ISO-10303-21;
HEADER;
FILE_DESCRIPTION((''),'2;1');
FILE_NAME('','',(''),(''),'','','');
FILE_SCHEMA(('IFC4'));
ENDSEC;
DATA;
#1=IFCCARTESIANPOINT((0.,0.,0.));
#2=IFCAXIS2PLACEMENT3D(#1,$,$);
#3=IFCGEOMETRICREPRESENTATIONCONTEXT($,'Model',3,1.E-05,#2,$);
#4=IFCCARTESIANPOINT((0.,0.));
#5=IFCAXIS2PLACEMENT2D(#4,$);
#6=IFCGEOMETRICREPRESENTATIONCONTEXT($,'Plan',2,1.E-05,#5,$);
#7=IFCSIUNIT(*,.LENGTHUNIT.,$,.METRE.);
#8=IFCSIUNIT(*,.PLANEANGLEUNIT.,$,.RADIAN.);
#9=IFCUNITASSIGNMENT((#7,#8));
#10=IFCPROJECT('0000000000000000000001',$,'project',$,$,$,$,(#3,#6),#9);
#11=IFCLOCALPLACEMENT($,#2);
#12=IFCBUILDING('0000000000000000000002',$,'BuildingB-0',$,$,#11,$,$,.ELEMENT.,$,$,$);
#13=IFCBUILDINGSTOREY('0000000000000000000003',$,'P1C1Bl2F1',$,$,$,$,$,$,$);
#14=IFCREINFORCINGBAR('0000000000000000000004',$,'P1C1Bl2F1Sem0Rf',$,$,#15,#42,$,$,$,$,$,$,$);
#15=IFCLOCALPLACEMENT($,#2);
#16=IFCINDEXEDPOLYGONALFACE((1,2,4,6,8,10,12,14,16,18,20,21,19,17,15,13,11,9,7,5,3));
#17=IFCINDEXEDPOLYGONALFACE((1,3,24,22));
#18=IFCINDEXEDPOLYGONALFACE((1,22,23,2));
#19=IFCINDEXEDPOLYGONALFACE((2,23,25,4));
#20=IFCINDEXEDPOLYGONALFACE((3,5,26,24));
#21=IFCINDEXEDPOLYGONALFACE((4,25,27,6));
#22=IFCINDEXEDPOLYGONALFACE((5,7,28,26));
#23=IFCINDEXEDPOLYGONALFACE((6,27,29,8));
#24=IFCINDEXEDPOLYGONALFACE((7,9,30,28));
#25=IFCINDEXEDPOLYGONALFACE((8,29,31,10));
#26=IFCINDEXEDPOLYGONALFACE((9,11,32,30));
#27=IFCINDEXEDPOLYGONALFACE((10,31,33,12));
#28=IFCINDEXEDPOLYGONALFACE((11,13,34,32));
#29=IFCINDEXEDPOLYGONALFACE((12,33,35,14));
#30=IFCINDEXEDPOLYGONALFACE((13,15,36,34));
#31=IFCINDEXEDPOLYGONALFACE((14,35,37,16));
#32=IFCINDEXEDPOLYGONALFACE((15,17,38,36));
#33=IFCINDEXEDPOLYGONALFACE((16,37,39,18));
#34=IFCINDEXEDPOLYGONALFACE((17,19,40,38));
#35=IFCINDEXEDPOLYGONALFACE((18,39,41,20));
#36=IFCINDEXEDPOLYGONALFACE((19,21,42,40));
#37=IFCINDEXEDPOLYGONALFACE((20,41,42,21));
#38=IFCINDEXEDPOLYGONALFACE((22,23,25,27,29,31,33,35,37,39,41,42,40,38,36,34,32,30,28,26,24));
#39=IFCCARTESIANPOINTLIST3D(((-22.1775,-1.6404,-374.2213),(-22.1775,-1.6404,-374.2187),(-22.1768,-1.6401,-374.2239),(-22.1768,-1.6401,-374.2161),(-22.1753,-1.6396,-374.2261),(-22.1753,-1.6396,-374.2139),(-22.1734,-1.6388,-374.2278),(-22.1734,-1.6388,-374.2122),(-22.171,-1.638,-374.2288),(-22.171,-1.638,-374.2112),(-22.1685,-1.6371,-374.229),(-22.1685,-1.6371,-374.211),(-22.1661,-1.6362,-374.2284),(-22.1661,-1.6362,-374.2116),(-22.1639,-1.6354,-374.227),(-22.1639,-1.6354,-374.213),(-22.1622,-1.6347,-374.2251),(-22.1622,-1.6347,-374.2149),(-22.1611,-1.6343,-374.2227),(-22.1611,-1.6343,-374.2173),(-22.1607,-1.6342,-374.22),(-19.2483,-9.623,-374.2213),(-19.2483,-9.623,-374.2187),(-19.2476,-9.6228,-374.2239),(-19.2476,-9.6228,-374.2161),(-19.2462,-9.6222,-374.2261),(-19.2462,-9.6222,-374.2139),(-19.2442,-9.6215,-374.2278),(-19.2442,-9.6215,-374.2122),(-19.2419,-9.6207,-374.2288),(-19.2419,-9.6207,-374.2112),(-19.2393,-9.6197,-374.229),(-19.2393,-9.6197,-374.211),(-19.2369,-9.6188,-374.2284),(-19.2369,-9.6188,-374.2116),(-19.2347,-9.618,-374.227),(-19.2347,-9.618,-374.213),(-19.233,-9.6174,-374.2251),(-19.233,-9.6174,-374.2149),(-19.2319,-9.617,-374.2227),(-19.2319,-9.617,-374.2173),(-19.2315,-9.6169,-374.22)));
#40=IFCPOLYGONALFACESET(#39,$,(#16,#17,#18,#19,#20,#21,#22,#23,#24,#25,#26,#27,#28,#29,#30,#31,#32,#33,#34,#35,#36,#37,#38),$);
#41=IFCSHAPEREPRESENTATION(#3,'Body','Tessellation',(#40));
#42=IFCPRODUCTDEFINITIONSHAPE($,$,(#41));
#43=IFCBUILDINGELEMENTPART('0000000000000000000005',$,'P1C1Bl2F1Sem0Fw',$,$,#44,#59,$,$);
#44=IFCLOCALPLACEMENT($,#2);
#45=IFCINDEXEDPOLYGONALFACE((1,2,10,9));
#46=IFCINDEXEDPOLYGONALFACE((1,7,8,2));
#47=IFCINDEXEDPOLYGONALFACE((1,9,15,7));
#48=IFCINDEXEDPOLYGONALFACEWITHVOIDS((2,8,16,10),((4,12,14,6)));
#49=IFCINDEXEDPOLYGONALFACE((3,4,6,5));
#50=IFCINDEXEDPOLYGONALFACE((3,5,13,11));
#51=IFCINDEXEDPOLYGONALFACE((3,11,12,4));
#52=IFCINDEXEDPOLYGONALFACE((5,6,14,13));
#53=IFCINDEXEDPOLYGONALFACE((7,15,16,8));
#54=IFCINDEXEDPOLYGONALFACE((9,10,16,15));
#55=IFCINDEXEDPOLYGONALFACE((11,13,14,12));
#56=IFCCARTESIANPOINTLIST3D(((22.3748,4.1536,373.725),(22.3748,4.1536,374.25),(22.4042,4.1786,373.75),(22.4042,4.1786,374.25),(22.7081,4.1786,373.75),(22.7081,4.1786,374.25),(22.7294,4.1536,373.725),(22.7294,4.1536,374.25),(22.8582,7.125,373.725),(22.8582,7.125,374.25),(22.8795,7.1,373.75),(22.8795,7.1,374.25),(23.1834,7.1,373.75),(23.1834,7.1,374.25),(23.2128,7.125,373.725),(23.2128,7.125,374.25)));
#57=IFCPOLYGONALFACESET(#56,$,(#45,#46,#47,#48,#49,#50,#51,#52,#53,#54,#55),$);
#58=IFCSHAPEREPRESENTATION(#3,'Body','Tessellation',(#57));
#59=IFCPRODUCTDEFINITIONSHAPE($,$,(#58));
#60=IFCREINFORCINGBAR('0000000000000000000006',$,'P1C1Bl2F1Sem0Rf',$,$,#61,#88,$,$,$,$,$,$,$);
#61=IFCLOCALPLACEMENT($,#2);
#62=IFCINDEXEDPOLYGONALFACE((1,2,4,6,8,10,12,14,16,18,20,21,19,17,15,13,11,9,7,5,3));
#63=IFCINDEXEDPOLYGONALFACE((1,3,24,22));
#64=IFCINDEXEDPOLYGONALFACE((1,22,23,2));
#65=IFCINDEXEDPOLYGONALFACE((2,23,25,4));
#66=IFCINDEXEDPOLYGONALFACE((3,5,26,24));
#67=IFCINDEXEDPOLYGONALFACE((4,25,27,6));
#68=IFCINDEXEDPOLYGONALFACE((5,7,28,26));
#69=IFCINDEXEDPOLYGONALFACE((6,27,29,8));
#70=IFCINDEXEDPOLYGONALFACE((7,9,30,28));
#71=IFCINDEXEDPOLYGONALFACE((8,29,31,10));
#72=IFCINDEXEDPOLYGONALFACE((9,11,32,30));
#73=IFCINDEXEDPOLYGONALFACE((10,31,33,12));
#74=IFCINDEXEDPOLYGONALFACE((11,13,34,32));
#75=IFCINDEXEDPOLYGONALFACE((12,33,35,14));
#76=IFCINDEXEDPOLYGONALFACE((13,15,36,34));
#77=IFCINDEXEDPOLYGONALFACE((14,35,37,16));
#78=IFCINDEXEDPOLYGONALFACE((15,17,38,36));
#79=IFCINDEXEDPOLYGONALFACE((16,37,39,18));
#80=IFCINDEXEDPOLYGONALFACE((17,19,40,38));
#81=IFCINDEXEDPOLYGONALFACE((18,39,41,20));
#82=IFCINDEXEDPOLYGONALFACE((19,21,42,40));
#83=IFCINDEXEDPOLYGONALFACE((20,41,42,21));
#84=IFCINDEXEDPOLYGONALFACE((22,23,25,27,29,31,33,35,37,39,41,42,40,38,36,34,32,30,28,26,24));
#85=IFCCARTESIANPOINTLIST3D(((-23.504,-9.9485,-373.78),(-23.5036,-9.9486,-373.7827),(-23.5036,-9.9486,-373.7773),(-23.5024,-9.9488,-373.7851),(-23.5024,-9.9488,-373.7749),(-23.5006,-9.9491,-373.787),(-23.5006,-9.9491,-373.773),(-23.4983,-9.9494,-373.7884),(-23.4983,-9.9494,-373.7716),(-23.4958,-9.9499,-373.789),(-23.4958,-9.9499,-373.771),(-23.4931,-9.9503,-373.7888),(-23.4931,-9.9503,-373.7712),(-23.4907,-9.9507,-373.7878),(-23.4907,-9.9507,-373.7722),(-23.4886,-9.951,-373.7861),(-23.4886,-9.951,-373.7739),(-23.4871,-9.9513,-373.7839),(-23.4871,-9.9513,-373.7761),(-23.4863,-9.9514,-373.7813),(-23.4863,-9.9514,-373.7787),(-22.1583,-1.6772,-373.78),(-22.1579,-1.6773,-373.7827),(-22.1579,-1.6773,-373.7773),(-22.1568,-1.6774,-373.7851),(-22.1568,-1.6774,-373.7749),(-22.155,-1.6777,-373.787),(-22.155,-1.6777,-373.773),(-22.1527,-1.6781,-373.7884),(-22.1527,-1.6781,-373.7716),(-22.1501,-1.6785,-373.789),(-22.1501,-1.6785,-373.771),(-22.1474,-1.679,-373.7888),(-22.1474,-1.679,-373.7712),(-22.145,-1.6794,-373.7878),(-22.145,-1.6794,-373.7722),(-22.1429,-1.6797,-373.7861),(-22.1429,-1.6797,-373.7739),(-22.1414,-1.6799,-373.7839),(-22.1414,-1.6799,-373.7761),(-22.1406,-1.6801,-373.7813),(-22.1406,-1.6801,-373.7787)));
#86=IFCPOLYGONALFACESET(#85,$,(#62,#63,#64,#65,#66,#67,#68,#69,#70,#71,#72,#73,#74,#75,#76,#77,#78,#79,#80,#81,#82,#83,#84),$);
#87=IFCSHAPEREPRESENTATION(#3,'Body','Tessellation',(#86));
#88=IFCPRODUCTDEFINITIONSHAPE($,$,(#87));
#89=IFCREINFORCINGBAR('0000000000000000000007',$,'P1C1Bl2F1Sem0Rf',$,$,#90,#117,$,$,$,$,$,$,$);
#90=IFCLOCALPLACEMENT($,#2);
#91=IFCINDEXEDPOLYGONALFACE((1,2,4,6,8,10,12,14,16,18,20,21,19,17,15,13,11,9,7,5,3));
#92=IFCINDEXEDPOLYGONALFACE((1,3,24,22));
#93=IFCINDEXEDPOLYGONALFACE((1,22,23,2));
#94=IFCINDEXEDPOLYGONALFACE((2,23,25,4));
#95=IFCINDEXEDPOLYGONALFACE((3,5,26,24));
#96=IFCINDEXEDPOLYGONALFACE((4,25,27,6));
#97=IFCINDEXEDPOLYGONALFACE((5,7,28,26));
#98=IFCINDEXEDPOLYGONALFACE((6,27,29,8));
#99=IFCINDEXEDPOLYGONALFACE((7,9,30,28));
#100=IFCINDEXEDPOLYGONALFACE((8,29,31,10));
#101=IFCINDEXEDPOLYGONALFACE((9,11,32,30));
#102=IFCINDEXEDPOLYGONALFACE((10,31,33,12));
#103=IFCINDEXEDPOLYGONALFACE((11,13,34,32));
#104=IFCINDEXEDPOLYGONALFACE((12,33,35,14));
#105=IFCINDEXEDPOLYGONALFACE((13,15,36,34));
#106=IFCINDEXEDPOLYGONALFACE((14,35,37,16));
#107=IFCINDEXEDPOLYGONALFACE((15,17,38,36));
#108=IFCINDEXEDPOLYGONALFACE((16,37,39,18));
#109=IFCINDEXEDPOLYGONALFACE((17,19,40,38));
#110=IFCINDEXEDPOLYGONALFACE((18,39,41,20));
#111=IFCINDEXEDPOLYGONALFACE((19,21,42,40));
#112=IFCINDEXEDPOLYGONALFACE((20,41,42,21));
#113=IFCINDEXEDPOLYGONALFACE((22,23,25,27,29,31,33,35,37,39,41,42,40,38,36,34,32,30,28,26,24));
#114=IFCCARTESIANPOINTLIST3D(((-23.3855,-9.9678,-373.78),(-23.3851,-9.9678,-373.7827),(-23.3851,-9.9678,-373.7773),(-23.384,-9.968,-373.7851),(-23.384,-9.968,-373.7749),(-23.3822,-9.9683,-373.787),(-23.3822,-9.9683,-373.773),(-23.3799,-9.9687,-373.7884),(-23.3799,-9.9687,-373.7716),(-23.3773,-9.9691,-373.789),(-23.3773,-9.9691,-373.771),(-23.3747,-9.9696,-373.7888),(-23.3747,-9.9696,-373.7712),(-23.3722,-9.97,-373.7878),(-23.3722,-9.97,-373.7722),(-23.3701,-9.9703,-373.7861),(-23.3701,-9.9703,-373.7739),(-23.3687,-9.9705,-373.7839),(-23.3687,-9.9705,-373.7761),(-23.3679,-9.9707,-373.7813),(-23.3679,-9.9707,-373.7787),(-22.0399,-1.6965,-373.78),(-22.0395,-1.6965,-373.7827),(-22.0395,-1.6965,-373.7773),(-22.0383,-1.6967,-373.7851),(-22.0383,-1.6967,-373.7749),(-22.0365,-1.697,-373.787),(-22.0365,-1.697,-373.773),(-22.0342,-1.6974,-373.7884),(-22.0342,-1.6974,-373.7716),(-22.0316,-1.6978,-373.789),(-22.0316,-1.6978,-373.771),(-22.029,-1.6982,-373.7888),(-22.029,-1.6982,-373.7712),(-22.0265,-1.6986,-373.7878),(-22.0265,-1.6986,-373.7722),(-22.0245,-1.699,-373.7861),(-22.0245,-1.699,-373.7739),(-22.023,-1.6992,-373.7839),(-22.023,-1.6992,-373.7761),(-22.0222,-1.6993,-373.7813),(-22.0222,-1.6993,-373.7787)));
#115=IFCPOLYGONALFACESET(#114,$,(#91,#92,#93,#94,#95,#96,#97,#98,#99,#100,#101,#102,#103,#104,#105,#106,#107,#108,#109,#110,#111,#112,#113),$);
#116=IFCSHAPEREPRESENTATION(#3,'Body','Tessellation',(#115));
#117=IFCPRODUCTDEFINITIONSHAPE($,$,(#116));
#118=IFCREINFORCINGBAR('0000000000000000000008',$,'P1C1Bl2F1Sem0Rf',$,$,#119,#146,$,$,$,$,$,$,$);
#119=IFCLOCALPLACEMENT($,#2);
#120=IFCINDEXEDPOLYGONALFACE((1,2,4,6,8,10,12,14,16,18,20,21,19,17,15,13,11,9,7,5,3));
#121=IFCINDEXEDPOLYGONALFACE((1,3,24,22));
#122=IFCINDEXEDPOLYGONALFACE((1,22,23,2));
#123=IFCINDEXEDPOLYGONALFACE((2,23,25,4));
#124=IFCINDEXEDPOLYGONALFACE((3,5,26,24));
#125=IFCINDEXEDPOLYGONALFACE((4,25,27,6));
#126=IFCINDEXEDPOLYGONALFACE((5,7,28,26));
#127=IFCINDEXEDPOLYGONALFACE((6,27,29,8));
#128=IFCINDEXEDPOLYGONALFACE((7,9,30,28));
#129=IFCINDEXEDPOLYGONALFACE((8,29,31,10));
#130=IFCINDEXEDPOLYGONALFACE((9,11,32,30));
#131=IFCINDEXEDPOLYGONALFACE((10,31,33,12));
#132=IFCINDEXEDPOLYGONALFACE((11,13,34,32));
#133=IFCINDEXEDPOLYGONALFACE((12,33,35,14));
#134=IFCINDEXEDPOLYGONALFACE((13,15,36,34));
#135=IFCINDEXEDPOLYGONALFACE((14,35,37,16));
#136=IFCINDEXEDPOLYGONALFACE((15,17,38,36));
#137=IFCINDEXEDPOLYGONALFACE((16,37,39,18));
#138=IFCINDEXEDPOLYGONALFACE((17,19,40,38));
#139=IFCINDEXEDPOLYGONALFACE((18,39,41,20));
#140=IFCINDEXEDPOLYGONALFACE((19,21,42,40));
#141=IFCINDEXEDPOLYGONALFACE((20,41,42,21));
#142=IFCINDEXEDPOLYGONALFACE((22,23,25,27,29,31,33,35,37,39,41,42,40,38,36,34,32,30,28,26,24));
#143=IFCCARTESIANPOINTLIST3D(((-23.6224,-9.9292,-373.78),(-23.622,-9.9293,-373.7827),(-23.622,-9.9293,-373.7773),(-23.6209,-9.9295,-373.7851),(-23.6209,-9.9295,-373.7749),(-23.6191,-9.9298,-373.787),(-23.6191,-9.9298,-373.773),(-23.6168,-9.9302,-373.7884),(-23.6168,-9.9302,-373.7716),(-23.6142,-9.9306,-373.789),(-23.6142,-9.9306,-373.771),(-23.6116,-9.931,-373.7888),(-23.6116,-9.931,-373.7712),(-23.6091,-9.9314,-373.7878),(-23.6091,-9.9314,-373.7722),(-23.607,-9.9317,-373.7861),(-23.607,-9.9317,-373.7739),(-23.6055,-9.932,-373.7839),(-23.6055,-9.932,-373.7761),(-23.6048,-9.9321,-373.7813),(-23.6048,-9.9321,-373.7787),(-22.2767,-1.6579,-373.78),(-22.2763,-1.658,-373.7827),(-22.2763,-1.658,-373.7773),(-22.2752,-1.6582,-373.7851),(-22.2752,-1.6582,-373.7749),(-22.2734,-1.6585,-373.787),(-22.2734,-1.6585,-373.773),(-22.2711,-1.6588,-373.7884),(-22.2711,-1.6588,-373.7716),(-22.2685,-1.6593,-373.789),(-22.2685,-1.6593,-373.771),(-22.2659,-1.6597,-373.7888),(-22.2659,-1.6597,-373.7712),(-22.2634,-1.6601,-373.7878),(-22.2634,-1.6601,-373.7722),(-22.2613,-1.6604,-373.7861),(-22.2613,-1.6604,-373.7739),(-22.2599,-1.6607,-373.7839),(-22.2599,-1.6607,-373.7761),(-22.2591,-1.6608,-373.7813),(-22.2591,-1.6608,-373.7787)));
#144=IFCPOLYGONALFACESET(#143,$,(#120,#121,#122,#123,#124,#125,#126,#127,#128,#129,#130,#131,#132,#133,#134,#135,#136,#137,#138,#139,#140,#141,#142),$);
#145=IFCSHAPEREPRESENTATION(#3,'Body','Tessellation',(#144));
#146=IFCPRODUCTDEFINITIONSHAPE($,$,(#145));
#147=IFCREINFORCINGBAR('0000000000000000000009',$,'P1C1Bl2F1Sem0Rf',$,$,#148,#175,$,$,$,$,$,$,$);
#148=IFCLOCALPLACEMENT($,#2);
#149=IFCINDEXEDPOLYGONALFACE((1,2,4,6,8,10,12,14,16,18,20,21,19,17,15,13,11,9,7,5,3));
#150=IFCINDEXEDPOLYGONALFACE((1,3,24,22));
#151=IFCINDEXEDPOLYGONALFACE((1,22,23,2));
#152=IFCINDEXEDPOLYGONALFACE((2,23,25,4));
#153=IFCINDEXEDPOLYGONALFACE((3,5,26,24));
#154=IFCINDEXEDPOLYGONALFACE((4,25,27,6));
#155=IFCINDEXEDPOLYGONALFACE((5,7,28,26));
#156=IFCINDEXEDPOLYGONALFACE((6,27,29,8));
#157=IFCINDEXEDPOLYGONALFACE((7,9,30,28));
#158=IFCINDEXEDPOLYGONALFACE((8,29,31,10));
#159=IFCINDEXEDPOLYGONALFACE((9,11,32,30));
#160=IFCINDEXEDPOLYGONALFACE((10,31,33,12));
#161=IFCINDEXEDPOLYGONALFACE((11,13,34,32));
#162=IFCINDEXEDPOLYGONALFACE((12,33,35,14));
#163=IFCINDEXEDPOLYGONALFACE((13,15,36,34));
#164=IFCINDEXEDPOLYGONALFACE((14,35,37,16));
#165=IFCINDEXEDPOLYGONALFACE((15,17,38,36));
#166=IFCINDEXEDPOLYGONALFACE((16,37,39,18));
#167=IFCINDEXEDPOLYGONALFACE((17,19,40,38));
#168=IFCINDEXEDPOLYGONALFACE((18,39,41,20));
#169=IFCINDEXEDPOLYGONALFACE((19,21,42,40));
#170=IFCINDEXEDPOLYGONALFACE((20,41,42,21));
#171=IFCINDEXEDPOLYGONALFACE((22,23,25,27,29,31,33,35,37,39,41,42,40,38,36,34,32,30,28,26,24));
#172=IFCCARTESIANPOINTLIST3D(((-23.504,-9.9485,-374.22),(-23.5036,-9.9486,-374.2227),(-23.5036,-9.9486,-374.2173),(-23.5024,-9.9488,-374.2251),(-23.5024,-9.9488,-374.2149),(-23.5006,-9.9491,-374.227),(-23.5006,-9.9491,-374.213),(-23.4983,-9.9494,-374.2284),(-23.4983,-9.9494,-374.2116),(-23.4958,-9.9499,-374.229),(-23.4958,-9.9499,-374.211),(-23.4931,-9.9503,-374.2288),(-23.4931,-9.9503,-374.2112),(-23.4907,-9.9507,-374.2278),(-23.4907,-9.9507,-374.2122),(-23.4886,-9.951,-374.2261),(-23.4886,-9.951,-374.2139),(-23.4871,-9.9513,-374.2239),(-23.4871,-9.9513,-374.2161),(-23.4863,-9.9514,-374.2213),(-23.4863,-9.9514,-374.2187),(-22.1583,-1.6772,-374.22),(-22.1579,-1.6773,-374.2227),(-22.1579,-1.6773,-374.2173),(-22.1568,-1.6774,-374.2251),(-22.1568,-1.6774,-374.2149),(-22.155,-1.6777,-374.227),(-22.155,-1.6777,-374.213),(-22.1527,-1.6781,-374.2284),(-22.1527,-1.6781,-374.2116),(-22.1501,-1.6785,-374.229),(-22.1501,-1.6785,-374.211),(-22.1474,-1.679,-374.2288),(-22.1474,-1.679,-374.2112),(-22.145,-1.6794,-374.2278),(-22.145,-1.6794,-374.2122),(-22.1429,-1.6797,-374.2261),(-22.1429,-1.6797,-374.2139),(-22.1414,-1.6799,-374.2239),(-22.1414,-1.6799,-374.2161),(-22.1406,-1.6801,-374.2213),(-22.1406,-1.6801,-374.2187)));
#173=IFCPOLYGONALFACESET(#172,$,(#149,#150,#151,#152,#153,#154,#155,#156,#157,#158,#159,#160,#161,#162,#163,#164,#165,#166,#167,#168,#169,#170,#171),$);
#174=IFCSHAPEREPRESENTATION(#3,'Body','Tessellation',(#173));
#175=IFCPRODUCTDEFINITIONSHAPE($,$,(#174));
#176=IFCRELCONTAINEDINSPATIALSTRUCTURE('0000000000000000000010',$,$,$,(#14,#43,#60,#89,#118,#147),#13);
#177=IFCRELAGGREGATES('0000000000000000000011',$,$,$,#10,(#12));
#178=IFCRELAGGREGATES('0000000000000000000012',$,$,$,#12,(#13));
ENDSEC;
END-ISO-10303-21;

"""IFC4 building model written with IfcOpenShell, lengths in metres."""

from ifc_helpers import new_model, entity, si_unit, origin, origin_2d, place, context, project, spatial, polyline, outline, extrude, element, save


model = new_model("IFC4")

# Units and contexts
model_context = context("Model", 3, precision=1e-05, world=origin())
plan_context = context("Plan", 2, precision=1e-05, world=origin_2d())
ifc_project = project(units=[si_unit("LENGTHUNIT", "METRE"), si_unit("PLANEANGLEUNIT", "RADIAN")], contexts=[model_context, plan_context])

# Building, storey
building_placement = place(None, origin())
building = spatial("IfcBuilding", under=ifc_project, at=building_placement, Name="BuildingB-0", CompositionType="ELEMENT")
storey = spatial("IfcBuildingStorey", under=building, Name="P1C1Bl2F1")

# Reinforcing bar
element("IfcReinforcingBar", 1, inside=storey, Name="P1C1Bl2F1Sem0Rf", context=model_context, shape_type="SweptSolid", body=[
    entity("IfcSurfaceCurveSweptAreaSolid", entity("IfcCircleProfileDef", "AREA", None, None, 0.009), None, entity("IfcPolyline", [entity("IfcCartesianPoint", [22.1692, 1.6373, 374.22]), entity("IfcCartesianPoint", [19.24, 9.62, 374.22])]), None, None, entity("IfcPlane", entity("IfcAxis2Placement3D", entity("IfcCartesianPoint", [22.1692, 1.6373, 374.22]), entity("IfcDirection", [0.0, 0.0, 1.0]), entity("IfcDirection", [1.0, 0.0, 0.0])))),
])

# Building element part, opening
building_element_part_1 = element("IfcBuildingElementPart", 2, inside=storey, Name="P1C1Bl2F1Sem0Fw", context=model_context, shape_type="SweptSolid", body=[
    extrude(outline(polyline([(22.3748, 4.1536, 373.725), (22.7294, 4.1536, 373.725), (23.2128, 7.125, 373.725), (22.8582, 7.125, 373.725), (22.3748, 4.1536, 373.725)])), None, (0.0, 0.0, 1.0), 0.525),
])
element("IfcOpeningElement", 3, inside=storey, cuts=building_element_part_1, context=model_context, shape_type="SweptSolid", body=[
    extrude(outline(polyline([(22.4042, 4.1786, 373.75), (22.7081, 4.1786, 373.75), (23.1834, 7.1, 373.75), (22.8795, 7.1, 373.75), (22.4042, 4.1786, 373.75)])), None, (0.0, 0.0, 1.0), 0.5),
])

# Reinforcing bars
element("IfcReinforcingBar", 4, inside=storey, Name="P1C1Bl2F1Sem0Rf", context=model_context, shape_type="SweptSolid", body=[
    entity("IfcSurfaceCurveSweptAreaSolid", entity("IfcCircleProfileDef", "AREA", None, None, 0.009), None, entity("IfcPolyline", [entity("IfcCartesianPoint", [23.4951, 9.95, 373.78]), entity("IfcCartesianPoint", [22.1494, 1.6786, 373.78])]), None, None, entity("IfcPlane", entity("IfcAxis2Placement3D", entity("IfcCartesianPoint", [23.4951, 9.95, 373.78]), entity("IfcDirection", [0.0, 0.0, 1.0]), entity("IfcDirection", [1.0, 0.0, 0.0])))),
])
element("IfcReinforcingBar", 5, inside=storey, Name="P1C1Bl2F1Sem0Rf", context=model_context, shape_type="SweptSolid", body=[
    entity("IfcSurfaceCurveSweptAreaSolid", entity("IfcCircleProfileDef", "AREA", None, None, 0.009), None, entity("IfcPolyline", [entity("IfcCartesianPoint", [23.3767, 9.9692, 373.78]), entity("IfcCartesianPoint", [22.031, 1.6979, 373.78])]), None, None, entity("IfcPlane", entity("IfcAxis2Placement3D", entity("IfcCartesianPoint", [23.3767, 9.9692, 373.78]), entity("IfcDirection", [0.0, 0.0, 1.0]), entity("IfcDirection", [1.0, 0.0, 0.0])))),
])
element("IfcReinforcingBar", 6, inside=storey, Name="P1C1Bl2F1Sem0Rf", context=model_context, shape_type="SweptSolid", body=[
    entity("IfcSurfaceCurveSweptAreaSolid", entity("IfcCircleProfileDef", "AREA", None, None, 0.009), None, entity("IfcPolyline", [entity("IfcCartesianPoint", [23.6135, 9.9307, 373.78]), entity("IfcCartesianPoint", [22.2679, 1.6594, 373.78])]), None, None, entity("IfcPlane", entity("IfcAxis2Placement3D", entity("IfcCartesianPoint", [23.6135, 9.9307, 373.78]), entity("IfcDirection", [0.0, 0.0, 1.0]), entity("IfcDirection", [1.0, 0.0, 0.0])))),
])
element("IfcReinforcingBar", 7, inside=storey, Name="P1C1Bl2F1Sem0Rf", context=model_context, shape_type="SweptSolid", body=[
    entity("IfcSurfaceCurveSweptAreaSolid", entity("IfcCircleProfileDef", "AREA", None, None, 0.009), None, entity("IfcPolyline", [entity("IfcCartesianPoint", [23.4951, 9.95, 374.22]), entity("IfcCartesianPoint", [22.1494, 1.6786, 374.22])]), None, None, entity("IfcPlane", entity("IfcAxis2Placement3D", entity("IfcCartesianPoint", [23.4951, 9.95, 374.22]), entity("IfcDirection", [0.0, 0.0, 1.0]), entity("IfcDirection", [1.0, 0.0, 0.0])))),
])

save(model, "model.ifc")
